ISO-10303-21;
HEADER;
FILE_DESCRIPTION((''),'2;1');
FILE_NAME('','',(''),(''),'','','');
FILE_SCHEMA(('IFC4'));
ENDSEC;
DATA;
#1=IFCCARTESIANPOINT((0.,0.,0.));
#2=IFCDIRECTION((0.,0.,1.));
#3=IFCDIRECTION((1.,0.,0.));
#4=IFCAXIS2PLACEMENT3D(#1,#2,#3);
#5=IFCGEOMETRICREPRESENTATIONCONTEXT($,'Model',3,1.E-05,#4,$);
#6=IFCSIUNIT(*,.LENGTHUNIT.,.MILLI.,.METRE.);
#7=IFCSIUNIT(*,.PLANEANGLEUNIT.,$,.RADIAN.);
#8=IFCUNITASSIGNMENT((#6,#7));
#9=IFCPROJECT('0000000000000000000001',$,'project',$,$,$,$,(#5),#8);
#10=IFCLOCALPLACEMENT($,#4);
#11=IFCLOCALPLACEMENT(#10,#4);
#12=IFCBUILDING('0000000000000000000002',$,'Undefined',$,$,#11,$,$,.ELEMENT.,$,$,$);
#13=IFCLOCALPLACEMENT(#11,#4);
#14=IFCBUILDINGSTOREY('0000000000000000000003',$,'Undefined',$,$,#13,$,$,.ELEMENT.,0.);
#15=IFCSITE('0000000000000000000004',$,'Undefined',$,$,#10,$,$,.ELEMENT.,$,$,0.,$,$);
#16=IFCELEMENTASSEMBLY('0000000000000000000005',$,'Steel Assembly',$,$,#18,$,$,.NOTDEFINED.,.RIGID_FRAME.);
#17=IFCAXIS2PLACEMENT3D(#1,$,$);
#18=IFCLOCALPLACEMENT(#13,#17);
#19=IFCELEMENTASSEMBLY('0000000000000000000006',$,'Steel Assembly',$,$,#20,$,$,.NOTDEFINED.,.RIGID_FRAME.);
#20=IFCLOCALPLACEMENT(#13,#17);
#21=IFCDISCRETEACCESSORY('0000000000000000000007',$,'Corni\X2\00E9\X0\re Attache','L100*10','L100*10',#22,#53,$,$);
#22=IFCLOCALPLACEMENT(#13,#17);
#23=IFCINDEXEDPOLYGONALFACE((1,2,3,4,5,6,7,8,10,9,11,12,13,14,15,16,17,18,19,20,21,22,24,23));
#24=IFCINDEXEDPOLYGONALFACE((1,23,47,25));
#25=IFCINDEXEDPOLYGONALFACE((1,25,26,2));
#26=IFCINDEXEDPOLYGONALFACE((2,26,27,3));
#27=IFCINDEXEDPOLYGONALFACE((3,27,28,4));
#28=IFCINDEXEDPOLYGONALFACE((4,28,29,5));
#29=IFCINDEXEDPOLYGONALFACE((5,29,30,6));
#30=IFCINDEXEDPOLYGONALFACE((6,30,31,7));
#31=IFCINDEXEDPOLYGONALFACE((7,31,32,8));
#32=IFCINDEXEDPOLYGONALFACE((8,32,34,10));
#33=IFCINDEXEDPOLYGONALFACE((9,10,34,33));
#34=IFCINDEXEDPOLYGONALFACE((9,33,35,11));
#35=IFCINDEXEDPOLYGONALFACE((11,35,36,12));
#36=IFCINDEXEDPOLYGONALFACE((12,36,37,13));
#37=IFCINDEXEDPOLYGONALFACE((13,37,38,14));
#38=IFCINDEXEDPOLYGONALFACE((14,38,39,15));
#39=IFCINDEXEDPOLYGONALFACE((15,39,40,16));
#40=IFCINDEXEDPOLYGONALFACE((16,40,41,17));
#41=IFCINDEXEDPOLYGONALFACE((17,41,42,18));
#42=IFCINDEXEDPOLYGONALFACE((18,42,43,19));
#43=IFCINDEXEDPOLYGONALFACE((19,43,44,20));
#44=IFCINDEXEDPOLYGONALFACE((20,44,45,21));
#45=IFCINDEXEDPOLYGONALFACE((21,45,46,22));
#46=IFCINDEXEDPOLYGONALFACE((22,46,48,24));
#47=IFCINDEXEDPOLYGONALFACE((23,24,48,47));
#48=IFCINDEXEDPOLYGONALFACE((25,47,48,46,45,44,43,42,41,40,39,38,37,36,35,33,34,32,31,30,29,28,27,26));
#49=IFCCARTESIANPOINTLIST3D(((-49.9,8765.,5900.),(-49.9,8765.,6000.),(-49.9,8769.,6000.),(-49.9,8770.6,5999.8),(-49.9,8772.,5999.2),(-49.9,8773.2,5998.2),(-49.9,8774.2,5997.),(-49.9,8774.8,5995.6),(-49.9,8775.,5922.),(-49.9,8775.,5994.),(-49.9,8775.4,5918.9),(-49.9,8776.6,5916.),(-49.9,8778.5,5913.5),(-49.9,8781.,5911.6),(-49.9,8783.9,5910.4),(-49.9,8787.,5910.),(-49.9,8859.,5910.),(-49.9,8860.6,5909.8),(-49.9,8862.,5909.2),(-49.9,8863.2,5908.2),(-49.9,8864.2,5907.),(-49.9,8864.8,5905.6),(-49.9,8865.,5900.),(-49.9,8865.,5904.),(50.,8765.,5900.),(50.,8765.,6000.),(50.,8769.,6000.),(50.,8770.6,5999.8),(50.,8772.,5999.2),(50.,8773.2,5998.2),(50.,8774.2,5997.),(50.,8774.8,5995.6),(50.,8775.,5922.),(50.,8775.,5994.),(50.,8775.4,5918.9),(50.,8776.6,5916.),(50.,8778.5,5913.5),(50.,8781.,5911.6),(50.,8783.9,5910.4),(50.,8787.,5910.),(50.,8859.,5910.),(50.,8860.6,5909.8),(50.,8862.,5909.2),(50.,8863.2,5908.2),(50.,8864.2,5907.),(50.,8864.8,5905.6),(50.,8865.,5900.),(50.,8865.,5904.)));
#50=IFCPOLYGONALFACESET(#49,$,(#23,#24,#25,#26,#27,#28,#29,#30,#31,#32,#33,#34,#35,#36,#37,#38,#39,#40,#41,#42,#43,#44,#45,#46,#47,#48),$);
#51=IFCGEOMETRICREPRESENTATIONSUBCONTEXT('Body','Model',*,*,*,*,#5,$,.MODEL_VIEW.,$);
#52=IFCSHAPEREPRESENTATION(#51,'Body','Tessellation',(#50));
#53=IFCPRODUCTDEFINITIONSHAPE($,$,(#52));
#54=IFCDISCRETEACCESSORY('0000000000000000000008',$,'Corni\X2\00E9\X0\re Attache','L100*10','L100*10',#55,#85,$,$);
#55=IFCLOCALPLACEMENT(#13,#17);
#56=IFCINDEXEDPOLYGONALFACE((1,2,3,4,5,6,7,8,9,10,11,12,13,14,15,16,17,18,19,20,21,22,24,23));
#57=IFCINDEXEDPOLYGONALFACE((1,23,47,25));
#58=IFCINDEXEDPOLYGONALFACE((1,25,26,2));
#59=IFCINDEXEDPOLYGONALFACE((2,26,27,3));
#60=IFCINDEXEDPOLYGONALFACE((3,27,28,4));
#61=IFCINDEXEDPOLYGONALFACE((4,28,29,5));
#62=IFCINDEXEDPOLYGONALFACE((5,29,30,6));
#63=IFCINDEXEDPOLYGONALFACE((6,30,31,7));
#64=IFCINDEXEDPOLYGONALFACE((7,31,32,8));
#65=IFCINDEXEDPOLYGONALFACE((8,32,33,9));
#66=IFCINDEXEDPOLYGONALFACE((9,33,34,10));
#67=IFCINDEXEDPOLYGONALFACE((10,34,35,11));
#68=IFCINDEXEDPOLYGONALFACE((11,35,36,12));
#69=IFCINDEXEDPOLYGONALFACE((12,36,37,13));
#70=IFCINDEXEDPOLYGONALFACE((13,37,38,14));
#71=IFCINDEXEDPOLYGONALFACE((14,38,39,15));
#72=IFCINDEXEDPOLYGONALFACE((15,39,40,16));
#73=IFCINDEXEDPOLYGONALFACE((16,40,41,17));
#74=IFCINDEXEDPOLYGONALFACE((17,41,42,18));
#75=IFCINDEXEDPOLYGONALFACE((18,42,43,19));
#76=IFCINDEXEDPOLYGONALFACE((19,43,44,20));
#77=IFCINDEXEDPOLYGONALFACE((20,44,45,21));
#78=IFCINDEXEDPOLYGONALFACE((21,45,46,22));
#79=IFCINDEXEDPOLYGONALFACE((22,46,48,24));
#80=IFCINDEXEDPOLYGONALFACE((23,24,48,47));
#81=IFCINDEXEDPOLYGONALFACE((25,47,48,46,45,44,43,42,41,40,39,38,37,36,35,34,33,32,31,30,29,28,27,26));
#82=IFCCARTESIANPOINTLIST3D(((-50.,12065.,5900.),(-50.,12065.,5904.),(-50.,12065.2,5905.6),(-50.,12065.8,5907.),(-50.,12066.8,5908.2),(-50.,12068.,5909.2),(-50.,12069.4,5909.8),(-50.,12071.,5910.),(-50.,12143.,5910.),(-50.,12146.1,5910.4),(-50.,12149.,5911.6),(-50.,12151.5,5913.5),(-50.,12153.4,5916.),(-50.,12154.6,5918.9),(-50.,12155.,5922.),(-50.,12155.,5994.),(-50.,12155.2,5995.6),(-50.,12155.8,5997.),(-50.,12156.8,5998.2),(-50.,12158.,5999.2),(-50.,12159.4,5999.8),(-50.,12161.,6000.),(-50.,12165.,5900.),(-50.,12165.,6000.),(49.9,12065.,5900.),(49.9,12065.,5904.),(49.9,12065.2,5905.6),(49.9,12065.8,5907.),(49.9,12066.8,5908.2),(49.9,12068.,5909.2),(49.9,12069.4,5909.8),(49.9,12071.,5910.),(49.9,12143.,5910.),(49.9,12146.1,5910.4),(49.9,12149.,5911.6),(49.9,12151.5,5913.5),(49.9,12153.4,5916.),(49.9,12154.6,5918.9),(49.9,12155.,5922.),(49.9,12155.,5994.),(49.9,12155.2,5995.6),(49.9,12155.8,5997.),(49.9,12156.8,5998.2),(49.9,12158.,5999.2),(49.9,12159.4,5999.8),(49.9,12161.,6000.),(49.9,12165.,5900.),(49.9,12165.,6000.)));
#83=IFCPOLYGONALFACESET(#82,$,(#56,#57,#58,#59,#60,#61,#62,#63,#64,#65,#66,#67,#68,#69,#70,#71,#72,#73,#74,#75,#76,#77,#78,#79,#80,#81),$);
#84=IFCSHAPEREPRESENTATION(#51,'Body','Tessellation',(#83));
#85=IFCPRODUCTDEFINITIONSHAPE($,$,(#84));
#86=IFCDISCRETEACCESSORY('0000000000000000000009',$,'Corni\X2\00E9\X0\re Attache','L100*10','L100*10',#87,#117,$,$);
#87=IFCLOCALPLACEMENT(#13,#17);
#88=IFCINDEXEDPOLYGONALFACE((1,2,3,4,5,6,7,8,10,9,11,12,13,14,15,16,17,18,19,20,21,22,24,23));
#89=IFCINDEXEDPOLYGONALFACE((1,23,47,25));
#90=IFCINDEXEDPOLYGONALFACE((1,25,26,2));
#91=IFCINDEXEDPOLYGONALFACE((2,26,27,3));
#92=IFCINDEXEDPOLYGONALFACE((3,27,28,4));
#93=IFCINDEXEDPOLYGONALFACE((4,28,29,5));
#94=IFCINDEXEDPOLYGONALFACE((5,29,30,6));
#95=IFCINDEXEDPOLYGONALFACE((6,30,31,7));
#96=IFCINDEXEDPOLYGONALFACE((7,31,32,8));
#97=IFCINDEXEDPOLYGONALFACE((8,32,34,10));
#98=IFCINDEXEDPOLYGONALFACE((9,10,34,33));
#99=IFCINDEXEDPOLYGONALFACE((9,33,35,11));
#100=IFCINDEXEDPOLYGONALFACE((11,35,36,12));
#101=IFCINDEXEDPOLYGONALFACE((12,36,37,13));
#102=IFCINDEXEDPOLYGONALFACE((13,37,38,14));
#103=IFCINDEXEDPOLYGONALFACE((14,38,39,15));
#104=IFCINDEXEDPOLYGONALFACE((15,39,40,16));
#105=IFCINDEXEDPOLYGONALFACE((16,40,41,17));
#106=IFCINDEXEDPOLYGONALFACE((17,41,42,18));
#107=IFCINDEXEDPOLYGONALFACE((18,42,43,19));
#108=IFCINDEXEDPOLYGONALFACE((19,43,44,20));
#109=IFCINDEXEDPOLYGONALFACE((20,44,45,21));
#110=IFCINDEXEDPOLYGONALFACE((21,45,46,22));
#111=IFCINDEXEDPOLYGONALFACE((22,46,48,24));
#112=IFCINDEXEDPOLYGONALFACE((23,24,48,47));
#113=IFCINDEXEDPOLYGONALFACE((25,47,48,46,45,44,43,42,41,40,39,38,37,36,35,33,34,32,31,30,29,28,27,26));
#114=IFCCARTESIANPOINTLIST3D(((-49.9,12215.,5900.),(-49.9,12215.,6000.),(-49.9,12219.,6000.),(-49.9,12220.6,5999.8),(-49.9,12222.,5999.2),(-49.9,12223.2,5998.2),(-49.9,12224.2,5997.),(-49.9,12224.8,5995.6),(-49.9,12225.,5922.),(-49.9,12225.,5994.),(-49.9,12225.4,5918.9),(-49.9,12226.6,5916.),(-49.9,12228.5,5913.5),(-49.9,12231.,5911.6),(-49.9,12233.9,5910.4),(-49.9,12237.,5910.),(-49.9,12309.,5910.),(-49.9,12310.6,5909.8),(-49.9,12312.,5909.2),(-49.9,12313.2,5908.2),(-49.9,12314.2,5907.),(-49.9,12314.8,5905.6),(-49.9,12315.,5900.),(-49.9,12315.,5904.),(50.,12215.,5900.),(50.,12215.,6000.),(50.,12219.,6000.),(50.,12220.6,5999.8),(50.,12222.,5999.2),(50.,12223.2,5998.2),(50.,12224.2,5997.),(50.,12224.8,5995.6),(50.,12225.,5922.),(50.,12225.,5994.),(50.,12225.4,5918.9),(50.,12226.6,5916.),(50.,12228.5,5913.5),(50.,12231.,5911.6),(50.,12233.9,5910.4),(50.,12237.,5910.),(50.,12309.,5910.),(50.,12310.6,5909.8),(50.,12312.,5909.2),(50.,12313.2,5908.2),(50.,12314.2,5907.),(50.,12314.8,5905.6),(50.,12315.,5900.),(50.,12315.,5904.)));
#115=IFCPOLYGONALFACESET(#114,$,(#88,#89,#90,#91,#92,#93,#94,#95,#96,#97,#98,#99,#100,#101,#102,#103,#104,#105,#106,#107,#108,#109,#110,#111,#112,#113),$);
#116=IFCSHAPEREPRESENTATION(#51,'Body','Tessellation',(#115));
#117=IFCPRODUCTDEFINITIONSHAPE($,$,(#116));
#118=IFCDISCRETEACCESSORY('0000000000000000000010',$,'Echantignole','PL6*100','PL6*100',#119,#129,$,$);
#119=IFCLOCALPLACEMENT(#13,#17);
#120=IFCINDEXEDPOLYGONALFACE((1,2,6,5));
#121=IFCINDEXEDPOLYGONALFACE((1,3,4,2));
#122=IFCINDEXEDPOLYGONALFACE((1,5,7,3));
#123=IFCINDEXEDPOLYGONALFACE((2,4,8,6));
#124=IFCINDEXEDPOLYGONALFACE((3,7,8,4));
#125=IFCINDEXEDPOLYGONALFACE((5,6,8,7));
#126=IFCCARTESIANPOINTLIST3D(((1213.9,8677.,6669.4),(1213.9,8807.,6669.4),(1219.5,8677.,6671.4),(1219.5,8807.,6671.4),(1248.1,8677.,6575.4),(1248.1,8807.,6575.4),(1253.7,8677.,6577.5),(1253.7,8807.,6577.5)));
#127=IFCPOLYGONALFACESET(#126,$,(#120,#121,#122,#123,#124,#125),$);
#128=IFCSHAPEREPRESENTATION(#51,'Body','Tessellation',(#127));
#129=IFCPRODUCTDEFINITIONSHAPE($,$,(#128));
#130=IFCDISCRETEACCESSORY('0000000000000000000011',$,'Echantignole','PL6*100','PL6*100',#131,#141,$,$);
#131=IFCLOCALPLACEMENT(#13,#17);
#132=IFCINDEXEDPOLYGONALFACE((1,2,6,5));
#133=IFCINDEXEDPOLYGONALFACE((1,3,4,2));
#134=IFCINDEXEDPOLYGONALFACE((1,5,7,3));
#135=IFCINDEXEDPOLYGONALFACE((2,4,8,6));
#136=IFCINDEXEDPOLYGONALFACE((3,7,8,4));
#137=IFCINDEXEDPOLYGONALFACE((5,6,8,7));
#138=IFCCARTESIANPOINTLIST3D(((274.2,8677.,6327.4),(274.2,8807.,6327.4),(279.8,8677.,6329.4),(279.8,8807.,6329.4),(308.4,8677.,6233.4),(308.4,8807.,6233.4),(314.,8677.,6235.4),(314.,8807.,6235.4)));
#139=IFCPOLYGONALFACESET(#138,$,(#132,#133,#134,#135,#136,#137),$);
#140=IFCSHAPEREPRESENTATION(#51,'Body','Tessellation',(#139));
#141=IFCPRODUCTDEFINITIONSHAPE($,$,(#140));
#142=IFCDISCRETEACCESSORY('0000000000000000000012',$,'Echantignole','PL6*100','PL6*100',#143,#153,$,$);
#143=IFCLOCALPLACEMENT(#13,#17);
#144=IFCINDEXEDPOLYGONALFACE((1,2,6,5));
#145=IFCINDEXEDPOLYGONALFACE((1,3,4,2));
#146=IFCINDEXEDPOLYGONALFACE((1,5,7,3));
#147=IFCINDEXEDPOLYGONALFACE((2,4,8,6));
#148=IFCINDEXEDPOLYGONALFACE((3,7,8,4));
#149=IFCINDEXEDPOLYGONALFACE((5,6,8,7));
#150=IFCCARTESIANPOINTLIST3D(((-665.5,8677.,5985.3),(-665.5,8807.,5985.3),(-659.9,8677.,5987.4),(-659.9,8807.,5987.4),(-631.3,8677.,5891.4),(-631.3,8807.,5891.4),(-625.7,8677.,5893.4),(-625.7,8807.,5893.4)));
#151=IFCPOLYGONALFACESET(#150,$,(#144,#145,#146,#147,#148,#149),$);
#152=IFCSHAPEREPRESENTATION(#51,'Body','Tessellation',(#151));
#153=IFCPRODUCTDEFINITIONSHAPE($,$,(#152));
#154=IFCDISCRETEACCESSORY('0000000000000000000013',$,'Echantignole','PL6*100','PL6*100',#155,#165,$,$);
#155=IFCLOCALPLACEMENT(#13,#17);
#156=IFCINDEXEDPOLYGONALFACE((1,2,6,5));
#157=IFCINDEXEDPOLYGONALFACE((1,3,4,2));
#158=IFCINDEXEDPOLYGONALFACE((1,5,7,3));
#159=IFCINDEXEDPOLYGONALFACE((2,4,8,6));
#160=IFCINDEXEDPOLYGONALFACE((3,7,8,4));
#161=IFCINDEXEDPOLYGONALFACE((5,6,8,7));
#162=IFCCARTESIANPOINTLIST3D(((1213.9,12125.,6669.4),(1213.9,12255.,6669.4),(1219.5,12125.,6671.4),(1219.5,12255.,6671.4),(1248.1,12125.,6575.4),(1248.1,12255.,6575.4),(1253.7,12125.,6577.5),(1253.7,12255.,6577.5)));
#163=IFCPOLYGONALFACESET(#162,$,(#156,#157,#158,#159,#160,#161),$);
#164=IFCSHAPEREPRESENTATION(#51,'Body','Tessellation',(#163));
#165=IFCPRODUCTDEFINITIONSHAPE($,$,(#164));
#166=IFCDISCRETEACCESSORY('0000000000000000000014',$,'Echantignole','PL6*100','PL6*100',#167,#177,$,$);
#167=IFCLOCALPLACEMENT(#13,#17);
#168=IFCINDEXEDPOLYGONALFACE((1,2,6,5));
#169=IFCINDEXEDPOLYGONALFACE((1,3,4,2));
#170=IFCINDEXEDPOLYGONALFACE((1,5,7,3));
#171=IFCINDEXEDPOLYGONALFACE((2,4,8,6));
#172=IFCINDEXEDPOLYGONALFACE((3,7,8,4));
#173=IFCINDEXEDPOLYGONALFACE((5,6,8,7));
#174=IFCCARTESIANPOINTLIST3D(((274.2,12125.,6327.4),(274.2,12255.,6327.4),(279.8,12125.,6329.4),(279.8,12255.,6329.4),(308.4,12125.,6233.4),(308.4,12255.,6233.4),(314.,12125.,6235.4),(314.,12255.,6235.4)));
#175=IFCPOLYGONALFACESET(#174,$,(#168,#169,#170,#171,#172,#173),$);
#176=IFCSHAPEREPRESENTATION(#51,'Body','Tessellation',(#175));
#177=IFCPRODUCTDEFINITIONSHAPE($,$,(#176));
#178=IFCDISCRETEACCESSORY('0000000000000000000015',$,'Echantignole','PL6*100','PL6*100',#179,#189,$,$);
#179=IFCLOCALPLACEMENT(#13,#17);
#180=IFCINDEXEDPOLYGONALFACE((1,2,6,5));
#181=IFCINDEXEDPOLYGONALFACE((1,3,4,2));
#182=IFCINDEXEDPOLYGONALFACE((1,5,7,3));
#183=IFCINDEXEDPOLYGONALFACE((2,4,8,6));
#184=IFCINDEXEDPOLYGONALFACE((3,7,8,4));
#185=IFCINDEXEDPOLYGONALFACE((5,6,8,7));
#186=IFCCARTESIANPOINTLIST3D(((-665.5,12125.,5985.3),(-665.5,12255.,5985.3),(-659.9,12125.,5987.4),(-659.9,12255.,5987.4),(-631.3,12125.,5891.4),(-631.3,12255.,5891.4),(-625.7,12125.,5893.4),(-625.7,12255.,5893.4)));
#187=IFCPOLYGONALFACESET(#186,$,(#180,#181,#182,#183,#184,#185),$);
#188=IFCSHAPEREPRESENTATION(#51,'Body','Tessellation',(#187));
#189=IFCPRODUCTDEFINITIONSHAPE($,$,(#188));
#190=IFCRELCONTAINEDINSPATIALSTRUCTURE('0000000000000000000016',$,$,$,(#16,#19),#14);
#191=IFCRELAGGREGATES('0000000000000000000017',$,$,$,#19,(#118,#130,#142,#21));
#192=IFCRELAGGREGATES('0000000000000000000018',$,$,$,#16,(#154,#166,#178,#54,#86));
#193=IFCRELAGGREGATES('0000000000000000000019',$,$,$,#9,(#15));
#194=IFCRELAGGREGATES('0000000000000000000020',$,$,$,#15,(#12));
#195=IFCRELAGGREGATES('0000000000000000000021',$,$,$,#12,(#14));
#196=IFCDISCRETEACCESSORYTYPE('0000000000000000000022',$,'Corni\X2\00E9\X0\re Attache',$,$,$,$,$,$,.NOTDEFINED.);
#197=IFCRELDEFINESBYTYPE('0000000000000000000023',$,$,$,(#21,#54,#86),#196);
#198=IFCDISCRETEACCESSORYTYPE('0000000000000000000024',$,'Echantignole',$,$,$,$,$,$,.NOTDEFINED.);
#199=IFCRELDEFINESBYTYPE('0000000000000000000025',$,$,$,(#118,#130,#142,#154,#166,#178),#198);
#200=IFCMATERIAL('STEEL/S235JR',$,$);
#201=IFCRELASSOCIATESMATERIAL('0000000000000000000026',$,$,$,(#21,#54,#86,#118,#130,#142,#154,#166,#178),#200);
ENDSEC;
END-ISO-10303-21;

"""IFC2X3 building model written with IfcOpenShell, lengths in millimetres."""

from ifc_helpers import new_model, si_unit, frame, origin_with_axes, origin_2d_with_axis, place, context, subcontext, project, spatial, polyline, l_section, outline, extrude, material, type_object, element, aggregate, save


model = new_model("IFC2X3")

# Units and contexts
model_context = context("Model", 3, precision=1e-05, world=origin_with_axes())
body_context = subcontext(model_context, "Body", "Model", "MODEL_VIEW")
ifc_project = project(units=[si_unit("LENGTHUNIT", "METRE", prefix="MILLI"), si_unit("PLANEANGLEUNIT", "RADIAN")], contexts=[model_context])

# Site, building, storey
site_placement = place(None, origin_with_axes())
site = spatial("IfcSite", under=ifc_project, at=site_placement, Name="Undefined", CompositionType="ELEMENT", RefElevation=0.0)
building_placement = place(site_placement, origin_with_axes())
building = spatial("IfcBuilding", under=site, at=building_placement, Name="Undefined", CompositionType="ELEMENT")
storey_placement = place(building_placement, origin_with_axes())
storey = spatial("IfcBuildingStorey", under=building, at=storey_placement, Name="Undefined", CompositionType="ELEMENT", Elevation=0.0)

# Shared definitions
ifc_material_1 = material(Name="STEEL/S235JR")

# Element assembly
assembly_1_placement = place(storey_placement, origin_with_axes())
assembly_1 = element("IfcElementAssembly", 1, at=assembly_1_placement, inside=storey, Name="Steel Assembly", AssemblyPlace="NOTDEFINED", PredefinedType="RIGID_FRAME")

# Element assembly, discrete accessory
assembly_2_placement = place(storey_placement, origin_with_axes())
assembly_2 = element("IfcElementAssembly", 2, at=assembly_2_placement, inside=storey, Name="Steel Assembly", AssemblyPlace="NOTDEFINED", PredefinedType="RIGID_FRAME")
discrete_accessory_type_1 = type_object("IfcDiscreteAccessoryType", Name="Corniére Attache")
discrete_accessory_1_placement = place(assembly_2_placement, frame((49.9, 8815.0, 5950.0), z_axis=(0.0, 0.0, 1.0), x_axis=(-1.0, 0.0, 0.0)))
discrete_accessory_1 = element("IfcDiscreteAccessory", 3, at=discrete_accessory_1_placement, type_object=discrete_accessory_type_1, material=ifc_material_1, Name="Corniére Attache", Description="L100*10", ObjectType="L100*10", context=body_context, shape_type="SweptSolid", body=[
    extrude(l_section(Depth=100.0, Width=100.0, Thickness=10.0, FilletRadius=12.0, EdgeRadius=6.0, at=origin_2d_with_axis()), frame((99.9, 0.0, 0.0), z_axis=(-1.0, 0.0, 0.0), x_axis=(0.0, -1.0, 0.0)), (0.0, 0.0, 1.0), 99.9),
])

# Discrete accessories
discrete_accessory_2_placement = place(assembly_1_placement, frame((-49.9, 12115.0, 5950.0), z_axis=(0.0, 0.0, 1.0), x_axis=(1.0, 0.0, 0.0)))
discrete_accessory_2 = element("IfcDiscreteAccessory", 4, at=discrete_accessory_2_placement, type_object=discrete_accessory_type_1, material=ifc_material_1, Name="Corniére Attache", Description="L100*10", ObjectType="L100*10", context=body_context, shape_type="SweptSolid", body=[
    extrude(l_section(Depth=100.0, Width=100.0, Thickness=10.0, FilletRadius=12.0, EdgeRadius=6.0, at=origin_2d_with_axis()), frame((99.9, 0.0, 0.0), z_axis=(-1.0, 0.0, 0.0), x_axis=(0.0, -1.0, 0.0)), (0.0, 0.0, 1.0), 99.9),
])
discrete_accessory_3_placement = place(assembly_1_placement, frame((49.9, 12265.0, 5950.0), z_axis=(0.0, 0.0, 1.0), x_axis=(-1.0, 0.0, 0.0)))
discrete_accessory_3 = element("IfcDiscreteAccessory", 5, at=discrete_accessory_3_placement, type_object=discrete_accessory_type_1, material=ifc_material_1, Name="Corniére Attache", Description="L100*10", ObjectType="L100*10", context=body_context, shape_type="SweptSolid", body=[
    extrude(l_section(Depth=100.0, Width=100.0, Thickness=10.0, FilletRadius=12.0, EdgeRadius=6.0, at=origin_2d_with_axis()), frame((99.9, 0.0, 0.0), z_axis=(-1.0, 0.0, 0.0), x_axis=(0.0, -1.0, 0.0)), (0.0, 0.0, 1.0), 99.9),
])
discrete_accessory_type_2 = type_object("IfcDiscreteAccessoryType", Name="Echantignole")
discrete_accessory_4_placement = place(assembly_2_placement, frame((1233.8, 8807.0, 6623.4), z_axis=(-0.939693, 0.0, -0.34202), x_axis=(0.0, -1.0, 0.0)))
discrete_accessory_4 = element("IfcDiscreteAccessory", 6, at=discrete_accessory_4_placement, type_object=discrete_accessory_type_2, material=ifc_material_1, Name="Echantignole", Description="PL6*100", ObjectType="PL6*100", context=body_context, shape_type="SweptSolid", body=[
    extrude(outline(polyline([(130.0, -50.0), (0.0, -50.0), (0.0, 50.0), (130.0, 50.0), (130.0, -50.0)])), frame((0.0, 0.0, -3.0), z_axis=(0.0, 0.0, 1.0), x_axis=(1.0, 0.0, 0.0)), (0.0, 0.0, 1.0), 6.0),
])
discrete_accessory_5_placement = place(assembly_2_placement, frame((294.1, 8807.0, 6281.4), z_axis=(-0.939693, 0.0, -0.34202), x_axis=(0.0, -1.0, 0.0)))
discrete_accessory_5 = element("IfcDiscreteAccessory", 7, at=discrete_accessory_5_placement, type_object=discrete_accessory_type_2, material=ifc_material_1, Name="Echantignole", Description="PL6*100", ObjectType="PL6*100", context=body_context, shape_type="SweptSolid", body=[
    extrude(outline(polyline([(130.0, -50.0), (0.0, -50.0), (0.0, 50.0), (130.0, 50.0), (130.0, -50.0)])), frame((0.0, 0.0, -3.0), z_axis=(0.0, 0.0, 1.0), x_axis=(1.0, 0.0, 0.0)), (0.0, 0.0, 1.0), 6.0),
])
discrete_accessory_6_placement = place(assembly_2_placement, frame((-645.6, 8807.0, 5939.4), z_axis=(-0.939693, 0.0, -0.34202), x_axis=(0.0, -1.0, 0.0)))
discrete_accessory_6 = element("IfcDiscreteAccessory", 8, at=discrete_accessory_6_placement, type_object=discrete_accessory_type_2, material=ifc_material_1, Name="Echantignole", Description="PL6*100", ObjectType="PL6*100", context=body_context, shape_type="SweptSolid", body=[
    extrude(outline(polyline([(130.0, -50.0), (0.0, -50.0), (0.0, 50.0), (130.0, 50.0), (130.0, -50.0)])), frame((0.0, 0.0, -3.0), z_axis=(0.0, 0.0, 1.0), x_axis=(1.0, 0.0, 0.0)), (0.0, 0.0, 1.0), 6.0),
])
discrete_accessory_7_placement = place(assembly_1_placement, frame((1233.8, 12255.0, 6623.4), z_axis=(-0.939693, 0.0, -0.34202), x_axis=(0.0, -1.0, 0.0)))
discrete_accessory_7 = element("IfcDiscreteAccessory", 9, at=discrete_accessory_7_placement, type_object=discrete_accessory_type_2, material=ifc_material_1, Name="Echantignole", Description="PL6*100", ObjectType="PL6*100", context=body_context, shape_type="SweptSolid", body=[
    extrude(outline(polyline([(130.0, -50.0), (0.0, -50.0), (0.0, 50.0), (130.0, 50.0), (130.0, -50.0)])), frame((0.0, 0.0, -3.0), z_axis=(0.0, 0.0, 1.0), x_axis=(1.0, 0.0, 0.0)), (0.0, 0.0, 1.0), 6.0),
])
discrete_accessory_8_placement = place(assembly_1_placement, frame((294.1, 12255.0, 6281.4), z_axis=(-0.939693, 0.0, -0.34202), x_axis=(0.0, -1.0, 0.0)))
discrete_accessory_8 = element("IfcDiscreteAccessory", 10, at=discrete_accessory_8_placement, type_object=discrete_accessory_type_2, material=ifc_material_1, Name="Echantignole", Description="PL6*100", ObjectType="PL6*100", context=body_context, shape_type="SweptSolid", body=[
    extrude(outline(polyline([(130.0, -50.0), (0.0, -50.0), (0.0, 50.0), (130.0, 50.0), (130.0, -50.0)])), frame((0.0, 0.0, -3.0), z_axis=(0.0, 0.0, 1.0), x_axis=(1.0, 0.0, 0.0)), (0.0, 0.0, 1.0), 6.0),
])
discrete_accessory_9_placement = place(assembly_1_placement, frame((-645.6, 12255.0, 5939.4), z_axis=(-0.939693, 0.0, -0.34202), x_axis=(0.0, -1.0, 0.0)))
discrete_accessory_9 = element("IfcDiscreteAccessory", 11, at=discrete_accessory_9_placement, type_object=discrete_accessory_type_2, material=ifc_material_1, Name="Echantignole", Description="PL6*100", ObjectType="PL6*100", context=body_context, shape_type="SweptSolid", body=[
    extrude(outline(polyline([(130.0, -50.0), (0.0, -50.0), (0.0, 50.0), (130.0, 50.0), (130.0, -50.0)])), frame((0.0, 0.0, -3.0), z_axis=(0.0, 0.0, 1.0), x_axis=(1.0, 0.0, 0.0)), (0.0, 0.0, 1.0), 6.0),
])

aggregate(assembly_2, [discrete_accessory_4, discrete_accessory_5, discrete_accessory_6, discrete_accessory_1])
aggregate(assembly_1, [discrete_accessory_7, discrete_accessory_8, discrete_accessory_9, discrete_accessory_2, discrete_accessory_3])

save(model, "model.ifc")
